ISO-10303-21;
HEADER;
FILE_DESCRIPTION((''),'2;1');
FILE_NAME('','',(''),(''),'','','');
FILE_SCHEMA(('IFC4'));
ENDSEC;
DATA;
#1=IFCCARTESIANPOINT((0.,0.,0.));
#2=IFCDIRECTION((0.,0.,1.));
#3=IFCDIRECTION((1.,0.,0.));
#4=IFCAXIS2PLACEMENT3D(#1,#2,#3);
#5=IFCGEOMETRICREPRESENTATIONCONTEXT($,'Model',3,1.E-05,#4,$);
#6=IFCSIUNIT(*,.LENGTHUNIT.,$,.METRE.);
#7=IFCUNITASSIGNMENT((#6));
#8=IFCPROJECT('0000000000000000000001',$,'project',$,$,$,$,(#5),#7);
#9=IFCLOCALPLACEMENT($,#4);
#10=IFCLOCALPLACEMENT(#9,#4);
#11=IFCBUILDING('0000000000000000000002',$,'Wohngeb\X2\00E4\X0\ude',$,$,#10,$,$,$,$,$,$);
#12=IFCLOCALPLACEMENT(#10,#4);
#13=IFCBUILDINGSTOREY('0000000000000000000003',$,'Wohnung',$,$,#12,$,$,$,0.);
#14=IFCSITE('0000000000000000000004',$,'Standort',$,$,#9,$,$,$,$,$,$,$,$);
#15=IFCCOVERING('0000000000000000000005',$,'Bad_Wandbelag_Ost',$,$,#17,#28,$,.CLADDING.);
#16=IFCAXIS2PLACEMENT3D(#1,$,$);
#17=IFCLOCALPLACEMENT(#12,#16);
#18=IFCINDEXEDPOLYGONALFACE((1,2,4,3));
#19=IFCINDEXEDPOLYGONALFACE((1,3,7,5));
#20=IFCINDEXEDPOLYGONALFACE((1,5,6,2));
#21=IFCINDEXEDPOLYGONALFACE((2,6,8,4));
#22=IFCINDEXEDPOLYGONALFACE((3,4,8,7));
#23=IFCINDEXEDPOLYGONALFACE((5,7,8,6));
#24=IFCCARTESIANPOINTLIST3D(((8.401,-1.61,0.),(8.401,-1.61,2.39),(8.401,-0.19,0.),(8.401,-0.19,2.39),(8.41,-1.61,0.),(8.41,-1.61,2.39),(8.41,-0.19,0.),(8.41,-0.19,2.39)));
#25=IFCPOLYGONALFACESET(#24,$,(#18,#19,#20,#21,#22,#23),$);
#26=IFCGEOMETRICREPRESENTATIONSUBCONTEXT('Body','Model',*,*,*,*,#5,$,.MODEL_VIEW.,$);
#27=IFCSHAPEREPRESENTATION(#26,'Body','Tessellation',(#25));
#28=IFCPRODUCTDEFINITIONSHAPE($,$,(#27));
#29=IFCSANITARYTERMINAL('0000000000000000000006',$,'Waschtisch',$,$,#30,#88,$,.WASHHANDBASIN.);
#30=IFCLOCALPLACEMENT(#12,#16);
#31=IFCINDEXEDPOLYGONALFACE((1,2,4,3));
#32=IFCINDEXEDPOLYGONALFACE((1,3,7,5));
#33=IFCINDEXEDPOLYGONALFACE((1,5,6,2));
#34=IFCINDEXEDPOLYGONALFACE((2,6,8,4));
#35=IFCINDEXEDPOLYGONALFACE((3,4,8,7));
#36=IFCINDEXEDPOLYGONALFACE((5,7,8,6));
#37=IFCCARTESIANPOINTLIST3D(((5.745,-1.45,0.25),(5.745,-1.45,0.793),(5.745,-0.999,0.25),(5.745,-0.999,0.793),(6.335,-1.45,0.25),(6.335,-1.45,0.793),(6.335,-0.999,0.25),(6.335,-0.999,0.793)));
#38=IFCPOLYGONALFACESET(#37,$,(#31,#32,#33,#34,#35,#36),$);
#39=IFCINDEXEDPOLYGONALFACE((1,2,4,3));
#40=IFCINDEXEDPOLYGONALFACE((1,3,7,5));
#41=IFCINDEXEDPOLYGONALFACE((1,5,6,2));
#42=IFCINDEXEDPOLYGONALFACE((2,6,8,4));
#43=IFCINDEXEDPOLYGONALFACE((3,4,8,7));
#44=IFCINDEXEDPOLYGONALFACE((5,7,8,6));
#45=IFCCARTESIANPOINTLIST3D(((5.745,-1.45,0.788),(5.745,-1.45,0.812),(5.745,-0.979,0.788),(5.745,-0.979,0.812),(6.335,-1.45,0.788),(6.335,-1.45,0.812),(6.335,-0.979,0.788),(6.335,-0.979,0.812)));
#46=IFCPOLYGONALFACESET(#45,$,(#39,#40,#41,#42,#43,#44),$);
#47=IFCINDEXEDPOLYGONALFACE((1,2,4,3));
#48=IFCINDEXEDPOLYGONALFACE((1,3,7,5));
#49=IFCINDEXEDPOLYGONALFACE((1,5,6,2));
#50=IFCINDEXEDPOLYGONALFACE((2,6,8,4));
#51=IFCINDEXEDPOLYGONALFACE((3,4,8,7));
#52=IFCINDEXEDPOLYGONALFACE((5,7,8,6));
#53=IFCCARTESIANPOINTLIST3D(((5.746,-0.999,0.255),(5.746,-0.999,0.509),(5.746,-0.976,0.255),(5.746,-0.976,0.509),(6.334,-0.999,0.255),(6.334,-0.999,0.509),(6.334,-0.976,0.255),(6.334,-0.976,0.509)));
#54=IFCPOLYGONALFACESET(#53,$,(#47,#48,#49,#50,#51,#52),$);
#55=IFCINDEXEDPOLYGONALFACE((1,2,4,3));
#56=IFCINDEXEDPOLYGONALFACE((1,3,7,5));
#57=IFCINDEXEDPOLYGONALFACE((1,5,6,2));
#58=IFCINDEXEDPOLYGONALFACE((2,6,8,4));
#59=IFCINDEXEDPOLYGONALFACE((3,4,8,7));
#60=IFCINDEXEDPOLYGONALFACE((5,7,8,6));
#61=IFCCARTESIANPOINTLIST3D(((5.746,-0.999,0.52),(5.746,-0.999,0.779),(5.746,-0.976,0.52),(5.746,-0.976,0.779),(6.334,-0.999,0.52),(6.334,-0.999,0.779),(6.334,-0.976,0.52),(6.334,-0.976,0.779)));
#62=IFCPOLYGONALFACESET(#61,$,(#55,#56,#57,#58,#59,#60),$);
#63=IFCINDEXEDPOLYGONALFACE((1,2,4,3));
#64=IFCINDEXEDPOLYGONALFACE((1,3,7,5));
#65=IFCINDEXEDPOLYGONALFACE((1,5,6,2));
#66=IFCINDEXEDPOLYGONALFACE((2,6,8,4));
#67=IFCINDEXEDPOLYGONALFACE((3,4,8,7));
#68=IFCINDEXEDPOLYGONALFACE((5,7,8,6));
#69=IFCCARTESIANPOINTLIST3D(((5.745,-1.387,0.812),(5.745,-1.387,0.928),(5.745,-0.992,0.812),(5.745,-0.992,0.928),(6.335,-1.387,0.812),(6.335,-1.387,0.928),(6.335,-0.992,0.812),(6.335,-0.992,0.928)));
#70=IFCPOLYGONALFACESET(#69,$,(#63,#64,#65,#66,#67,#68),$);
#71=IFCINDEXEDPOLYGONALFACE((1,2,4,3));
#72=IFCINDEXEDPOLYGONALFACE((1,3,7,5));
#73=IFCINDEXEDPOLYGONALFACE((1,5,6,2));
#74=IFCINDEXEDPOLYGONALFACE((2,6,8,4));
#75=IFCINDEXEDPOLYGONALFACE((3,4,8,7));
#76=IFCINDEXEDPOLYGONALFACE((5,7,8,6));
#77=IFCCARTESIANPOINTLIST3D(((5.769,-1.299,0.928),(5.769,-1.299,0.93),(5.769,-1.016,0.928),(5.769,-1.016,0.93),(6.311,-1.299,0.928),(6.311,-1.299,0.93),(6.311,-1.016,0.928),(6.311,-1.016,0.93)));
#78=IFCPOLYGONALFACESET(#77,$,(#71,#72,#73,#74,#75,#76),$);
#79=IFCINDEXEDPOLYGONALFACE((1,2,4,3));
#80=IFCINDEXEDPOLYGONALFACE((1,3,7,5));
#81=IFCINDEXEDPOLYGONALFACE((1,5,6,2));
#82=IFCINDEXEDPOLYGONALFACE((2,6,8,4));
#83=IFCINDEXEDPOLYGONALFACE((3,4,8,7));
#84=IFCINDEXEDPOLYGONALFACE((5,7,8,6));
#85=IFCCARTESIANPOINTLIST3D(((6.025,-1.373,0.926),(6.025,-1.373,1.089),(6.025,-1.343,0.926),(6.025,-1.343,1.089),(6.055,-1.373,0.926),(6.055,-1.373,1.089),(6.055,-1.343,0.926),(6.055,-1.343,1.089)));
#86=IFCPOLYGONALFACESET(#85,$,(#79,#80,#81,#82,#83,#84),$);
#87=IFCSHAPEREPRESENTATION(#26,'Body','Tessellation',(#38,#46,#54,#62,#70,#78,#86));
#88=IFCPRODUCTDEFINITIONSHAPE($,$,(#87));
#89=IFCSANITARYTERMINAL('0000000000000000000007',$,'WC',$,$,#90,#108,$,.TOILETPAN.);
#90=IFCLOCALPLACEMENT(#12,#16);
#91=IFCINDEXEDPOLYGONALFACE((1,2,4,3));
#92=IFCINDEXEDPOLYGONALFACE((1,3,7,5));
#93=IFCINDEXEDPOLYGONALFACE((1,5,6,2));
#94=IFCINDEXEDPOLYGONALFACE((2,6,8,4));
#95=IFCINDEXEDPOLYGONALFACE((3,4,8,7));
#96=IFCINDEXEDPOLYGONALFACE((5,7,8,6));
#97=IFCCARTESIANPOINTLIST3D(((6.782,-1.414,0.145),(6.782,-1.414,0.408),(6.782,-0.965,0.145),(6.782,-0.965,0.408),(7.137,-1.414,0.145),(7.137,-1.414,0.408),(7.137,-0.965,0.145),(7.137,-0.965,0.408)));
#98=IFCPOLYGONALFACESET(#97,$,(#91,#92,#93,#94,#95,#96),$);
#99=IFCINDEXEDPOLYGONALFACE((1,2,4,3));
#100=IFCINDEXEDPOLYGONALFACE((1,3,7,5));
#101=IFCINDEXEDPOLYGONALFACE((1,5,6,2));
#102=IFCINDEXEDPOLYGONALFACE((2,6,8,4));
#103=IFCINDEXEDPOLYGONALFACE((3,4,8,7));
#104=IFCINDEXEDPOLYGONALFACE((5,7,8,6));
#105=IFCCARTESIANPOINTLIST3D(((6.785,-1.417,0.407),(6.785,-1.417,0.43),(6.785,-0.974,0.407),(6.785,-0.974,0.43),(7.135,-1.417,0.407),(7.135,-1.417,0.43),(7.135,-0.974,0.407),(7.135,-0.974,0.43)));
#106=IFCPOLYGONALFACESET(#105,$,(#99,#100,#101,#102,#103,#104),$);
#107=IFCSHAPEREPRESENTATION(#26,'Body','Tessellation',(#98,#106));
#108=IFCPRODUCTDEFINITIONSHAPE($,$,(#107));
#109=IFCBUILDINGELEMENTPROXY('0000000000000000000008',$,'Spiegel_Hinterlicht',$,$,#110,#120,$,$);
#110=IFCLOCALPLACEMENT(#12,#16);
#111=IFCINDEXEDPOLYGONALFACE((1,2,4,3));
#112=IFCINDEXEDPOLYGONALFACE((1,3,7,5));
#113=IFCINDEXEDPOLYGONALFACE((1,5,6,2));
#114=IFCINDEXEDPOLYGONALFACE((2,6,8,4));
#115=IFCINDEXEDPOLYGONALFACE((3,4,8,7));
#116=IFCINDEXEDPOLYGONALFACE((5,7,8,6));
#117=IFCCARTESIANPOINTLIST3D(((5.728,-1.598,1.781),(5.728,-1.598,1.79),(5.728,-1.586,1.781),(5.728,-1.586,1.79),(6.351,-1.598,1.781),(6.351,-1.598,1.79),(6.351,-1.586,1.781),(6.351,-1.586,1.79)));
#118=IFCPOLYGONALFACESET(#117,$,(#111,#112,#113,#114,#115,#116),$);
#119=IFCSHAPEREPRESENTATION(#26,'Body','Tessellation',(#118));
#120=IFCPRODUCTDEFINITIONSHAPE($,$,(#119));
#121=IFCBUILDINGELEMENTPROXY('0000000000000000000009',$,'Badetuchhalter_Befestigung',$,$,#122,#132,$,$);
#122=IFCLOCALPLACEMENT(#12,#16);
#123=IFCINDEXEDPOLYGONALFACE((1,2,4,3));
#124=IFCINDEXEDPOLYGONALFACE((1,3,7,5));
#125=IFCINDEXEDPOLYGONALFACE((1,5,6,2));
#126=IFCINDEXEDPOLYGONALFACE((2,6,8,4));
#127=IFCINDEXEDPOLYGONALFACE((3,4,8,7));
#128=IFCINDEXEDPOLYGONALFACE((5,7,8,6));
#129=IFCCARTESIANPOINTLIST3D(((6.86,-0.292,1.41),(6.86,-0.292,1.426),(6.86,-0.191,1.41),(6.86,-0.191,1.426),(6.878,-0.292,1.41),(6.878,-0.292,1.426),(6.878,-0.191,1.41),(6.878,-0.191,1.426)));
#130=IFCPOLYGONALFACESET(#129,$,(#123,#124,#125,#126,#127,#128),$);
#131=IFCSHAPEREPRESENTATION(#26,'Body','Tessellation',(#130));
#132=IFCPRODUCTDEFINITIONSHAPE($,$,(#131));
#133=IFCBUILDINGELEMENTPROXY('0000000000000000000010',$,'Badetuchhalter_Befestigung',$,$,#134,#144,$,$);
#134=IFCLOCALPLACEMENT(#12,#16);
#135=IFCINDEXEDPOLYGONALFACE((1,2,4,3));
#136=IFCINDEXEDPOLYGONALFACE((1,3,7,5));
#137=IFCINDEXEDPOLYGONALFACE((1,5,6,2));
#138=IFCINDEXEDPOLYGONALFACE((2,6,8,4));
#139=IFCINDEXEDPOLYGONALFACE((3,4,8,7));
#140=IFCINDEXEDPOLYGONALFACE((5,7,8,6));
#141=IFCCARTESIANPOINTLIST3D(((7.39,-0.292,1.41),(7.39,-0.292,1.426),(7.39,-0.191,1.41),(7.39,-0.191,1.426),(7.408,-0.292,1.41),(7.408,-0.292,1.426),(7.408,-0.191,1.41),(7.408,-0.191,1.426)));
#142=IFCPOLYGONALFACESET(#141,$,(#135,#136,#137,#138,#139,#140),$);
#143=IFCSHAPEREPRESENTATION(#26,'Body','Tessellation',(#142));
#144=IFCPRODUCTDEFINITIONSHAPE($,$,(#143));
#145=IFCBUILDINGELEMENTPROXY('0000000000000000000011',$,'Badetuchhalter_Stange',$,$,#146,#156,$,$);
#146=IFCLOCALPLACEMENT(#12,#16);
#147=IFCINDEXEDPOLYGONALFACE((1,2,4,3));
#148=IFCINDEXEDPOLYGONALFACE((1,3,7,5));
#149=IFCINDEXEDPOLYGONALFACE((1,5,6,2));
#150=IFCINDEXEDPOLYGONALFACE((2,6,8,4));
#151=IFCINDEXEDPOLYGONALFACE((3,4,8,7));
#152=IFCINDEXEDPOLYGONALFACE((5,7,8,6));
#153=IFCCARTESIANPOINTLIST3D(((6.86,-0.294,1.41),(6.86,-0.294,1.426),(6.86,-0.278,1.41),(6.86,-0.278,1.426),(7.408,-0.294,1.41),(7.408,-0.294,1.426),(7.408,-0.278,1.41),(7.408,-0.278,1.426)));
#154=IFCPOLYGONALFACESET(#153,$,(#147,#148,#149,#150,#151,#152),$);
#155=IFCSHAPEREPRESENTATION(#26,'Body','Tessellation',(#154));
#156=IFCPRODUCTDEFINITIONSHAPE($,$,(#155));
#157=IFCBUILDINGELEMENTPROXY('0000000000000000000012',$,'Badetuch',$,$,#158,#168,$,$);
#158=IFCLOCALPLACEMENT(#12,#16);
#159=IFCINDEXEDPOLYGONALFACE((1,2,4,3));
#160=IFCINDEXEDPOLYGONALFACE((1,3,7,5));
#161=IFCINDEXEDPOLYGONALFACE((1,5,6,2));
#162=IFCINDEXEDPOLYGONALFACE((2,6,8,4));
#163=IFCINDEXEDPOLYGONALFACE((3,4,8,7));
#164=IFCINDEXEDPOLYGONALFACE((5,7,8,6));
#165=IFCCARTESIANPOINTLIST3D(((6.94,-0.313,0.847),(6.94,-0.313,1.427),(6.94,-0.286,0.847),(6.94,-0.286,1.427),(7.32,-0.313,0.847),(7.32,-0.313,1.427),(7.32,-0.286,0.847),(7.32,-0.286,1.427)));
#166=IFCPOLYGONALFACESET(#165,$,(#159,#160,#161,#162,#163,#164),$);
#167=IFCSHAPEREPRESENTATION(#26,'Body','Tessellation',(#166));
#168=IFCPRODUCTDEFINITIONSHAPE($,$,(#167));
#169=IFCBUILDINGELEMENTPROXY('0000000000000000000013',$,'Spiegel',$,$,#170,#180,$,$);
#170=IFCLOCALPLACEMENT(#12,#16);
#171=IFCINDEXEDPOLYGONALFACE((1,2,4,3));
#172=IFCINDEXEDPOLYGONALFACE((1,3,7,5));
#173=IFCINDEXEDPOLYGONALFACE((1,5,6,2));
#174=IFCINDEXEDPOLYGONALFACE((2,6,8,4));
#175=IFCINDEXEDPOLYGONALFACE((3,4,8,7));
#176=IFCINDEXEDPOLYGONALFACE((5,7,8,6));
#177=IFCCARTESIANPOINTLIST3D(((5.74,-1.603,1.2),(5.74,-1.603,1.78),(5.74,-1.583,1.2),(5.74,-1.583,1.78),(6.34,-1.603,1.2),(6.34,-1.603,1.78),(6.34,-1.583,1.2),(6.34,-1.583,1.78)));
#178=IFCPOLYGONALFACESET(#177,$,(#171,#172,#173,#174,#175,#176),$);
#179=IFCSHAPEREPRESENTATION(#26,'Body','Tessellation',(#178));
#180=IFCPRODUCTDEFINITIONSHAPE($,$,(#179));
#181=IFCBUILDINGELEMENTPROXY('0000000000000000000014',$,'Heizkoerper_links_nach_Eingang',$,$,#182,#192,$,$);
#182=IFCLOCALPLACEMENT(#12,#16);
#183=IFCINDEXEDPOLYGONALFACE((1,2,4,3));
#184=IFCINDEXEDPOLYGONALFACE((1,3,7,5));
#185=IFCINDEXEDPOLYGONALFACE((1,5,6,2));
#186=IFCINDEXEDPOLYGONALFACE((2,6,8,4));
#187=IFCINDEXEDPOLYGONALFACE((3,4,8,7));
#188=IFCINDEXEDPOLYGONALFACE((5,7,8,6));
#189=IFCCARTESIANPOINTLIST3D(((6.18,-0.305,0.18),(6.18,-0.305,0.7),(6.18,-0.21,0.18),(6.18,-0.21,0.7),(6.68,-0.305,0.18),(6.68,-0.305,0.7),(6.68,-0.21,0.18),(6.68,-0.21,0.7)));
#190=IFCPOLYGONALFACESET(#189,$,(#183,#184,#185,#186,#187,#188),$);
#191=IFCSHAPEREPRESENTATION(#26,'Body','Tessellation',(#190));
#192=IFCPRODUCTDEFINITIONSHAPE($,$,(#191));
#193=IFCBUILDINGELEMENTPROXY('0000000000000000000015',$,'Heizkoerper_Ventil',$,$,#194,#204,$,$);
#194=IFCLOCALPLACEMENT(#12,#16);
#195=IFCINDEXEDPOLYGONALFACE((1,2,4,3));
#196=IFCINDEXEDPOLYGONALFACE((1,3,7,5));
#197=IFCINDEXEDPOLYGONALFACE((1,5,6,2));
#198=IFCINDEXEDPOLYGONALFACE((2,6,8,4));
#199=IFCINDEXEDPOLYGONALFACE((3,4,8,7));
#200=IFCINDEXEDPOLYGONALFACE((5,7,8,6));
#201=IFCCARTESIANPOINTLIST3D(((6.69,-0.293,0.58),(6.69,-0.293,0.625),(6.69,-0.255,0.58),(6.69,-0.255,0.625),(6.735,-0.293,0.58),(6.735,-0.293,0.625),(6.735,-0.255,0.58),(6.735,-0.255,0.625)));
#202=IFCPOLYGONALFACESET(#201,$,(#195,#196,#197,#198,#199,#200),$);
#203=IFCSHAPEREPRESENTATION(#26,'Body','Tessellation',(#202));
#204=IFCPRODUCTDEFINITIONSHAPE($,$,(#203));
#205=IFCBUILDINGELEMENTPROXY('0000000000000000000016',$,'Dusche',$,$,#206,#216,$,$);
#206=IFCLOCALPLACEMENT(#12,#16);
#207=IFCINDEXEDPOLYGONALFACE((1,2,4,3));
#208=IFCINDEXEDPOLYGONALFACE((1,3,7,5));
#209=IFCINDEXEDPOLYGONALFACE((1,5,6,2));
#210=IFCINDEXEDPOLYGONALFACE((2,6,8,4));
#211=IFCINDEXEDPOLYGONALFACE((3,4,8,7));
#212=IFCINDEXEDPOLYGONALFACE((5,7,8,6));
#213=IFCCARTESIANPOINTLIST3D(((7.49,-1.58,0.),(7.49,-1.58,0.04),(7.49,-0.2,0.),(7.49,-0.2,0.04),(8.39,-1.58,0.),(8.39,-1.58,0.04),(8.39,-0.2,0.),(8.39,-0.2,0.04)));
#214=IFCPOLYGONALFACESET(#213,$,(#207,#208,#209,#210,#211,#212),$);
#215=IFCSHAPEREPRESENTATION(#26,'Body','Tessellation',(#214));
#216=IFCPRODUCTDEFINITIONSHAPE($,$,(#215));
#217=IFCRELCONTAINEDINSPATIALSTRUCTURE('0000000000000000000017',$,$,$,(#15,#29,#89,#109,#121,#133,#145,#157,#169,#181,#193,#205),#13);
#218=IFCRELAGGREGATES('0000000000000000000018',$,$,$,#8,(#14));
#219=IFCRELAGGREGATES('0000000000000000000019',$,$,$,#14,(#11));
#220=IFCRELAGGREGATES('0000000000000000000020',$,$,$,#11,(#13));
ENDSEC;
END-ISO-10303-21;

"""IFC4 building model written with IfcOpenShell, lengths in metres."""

from ifc_helpers import new_model, si_unit, frame, origin, origin_with_axes, place, context, subcontext, project, spatial, polyline, outline, extrude, element, save


model = new_model("IFC4")

# Units and contexts
model_context = context("Model", 3, precision=1e-05, world=origin_with_axes())
body_context = subcontext(model_context, "Body", "Model", "MODEL_VIEW")
ifc_project = project(units=[si_unit("LENGTHUNIT", "METRE")], contexts=[model_context])

# Site, building, storey
site_placement = place(None, origin_with_axes())
site = spatial("IfcSite", under=ifc_project, at=site_placement, Name="Standort")
building_placement = place(site_placement, origin_with_axes())
building = spatial("IfcBuilding", under=site, at=building_placement, Name="Wohngebäude")
storey_placement = place(building_placement, origin_with_axes())
storey = spatial("IfcBuildingStorey", under=building, at=storey_placement, Name="Wohnung", Elevation=0.0)

# Covering
covering_placement = place(storey_placement, frame((8.401, -0.19, 0.0), z_axis=(0.0, 0.0, 1.0), x_axis=(1.0, 0.0, 0.0)))
element("IfcCovering", 1, at=covering_placement, inside=storey, Name="Bad_Wandbelag_Ost", PredefinedType="CLADDING", context=body_context, shape_type="SweptSolid", body=[
    extrude(outline(polyline([(0.0, 0.0), (0.0, -1.42), (0.009, -1.42), (0.009, 0.0), (0.0, 0.0)])), origin(), (0.0, 0.0, 1.0), 2.39),
])

# Sanitary terminals
sanitary_terminal_1_placement = place(storey_placement, frame((5.745, -0.976, 0.25), z_axis=(0.0, 0.0, 1.0), x_axis=(1.0, 0.0, 0.0)))
element("IfcSanitaryTerminal", 2, at=sanitary_terminal_1_placement, inside=storey, Name="Waschtisch", PredefinedType="WASHHANDBASIN", context=body_context, shape_type="SweptSolid", body=[
    extrude(outline(polyline([(0.0, -0.023), (0.0, -0.474), (0.59, -0.474), (0.59, -0.023), (0.0, -0.023)])), origin(), (0.0, 0.0, 1.0), 0.543),
    extrude(outline(polyline([(0.0, -0.003), (0.0, -0.474), (0.59, -0.474), (0.59, -0.003), (0.0, -0.003)])), frame((0.0, 0.0, 0.538)), (0.0, 0.0, 1.0), 0.024),
    extrude(outline(polyline([(0.001, 0.0), (0.001, -0.023), (0.589, -0.023), (0.589, 0.0), (0.001, 0.0)])), frame((0.0, 0.0, 0.005)), (0.0, 0.0, 1.0), 0.254),
    extrude(outline(polyline([(0.001, 0.0), (0.001, -0.023), (0.589, -0.023), (0.589, 0.0), (0.001, 0.0)])), frame((0.0, 0.0, 0.27)), (0.0, 0.0, 1.0), 0.259),
    extrude(outline(polyline([(0.0, -0.016), (0.0, -0.411), (0.59, -0.411), (0.59, -0.016), (0.0, -0.016)])), frame((0.0, 0.0, 0.562)), (0.0, 0.0, 1.0), 0.116),
    extrude(outline(polyline([(0.024, -0.04), (0.024, -0.323), (0.566, -0.323), (0.566, -0.04), (0.024, -0.04)])), frame((0.0, 0.0, 0.678)), (0.0, 0.0, 1.0), 0.002),
    extrude(outline(polyline([(0.28, -0.367), (0.28, -0.397), (0.31, -0.397), (0.31, -0.367), (0.28, -0.367)])), frame((0.0, 0.0, 0.676)), (0.0, 0.0, 1.0), 0.163),
])
sanitary_terminal_2_placement = place(storey_placement, frame((6.782, -0.965, 0.145), z_axis=(0.0, 0.0, 1.0), x_axis=(1.0, 0.0, 0.0)))
element("IfcSanitaryTerminal", 3, at=sanitary_terminal_2_placement, inside=storey, Name="WC", PredefinedType="TOILETPAN", context=body_context, shape_type="SweptSolid", body=[
    extrude(outline(polyline([(0.0, 0.0), (0.0, -0.449), (0.355, -0.449), (0.355, 0.0), (0.0, 0.0)])), origin(), (0.0, 0.0, 1.0), 0.263),
    extrude(outline(polyline([(0.003, -0.009), (0.003, -0.452), (0.353, -0.452), (0.353, -0.009), (0.003, -0.009)])), frame((0.0, 0.0, 0.262)), (0.0, 0.0, 1.0), 0.023),
])

# Building element proxies
proxy_1_placement = place(storey_placement, frame((5.728, -1.586, 1.781), z_axis=(0.0, 0.0, 1.0), x_axis=(1.0, 0.0, 0.0)))
element("IfcBuildingElementProxy", 4, at=proxy_1_placement, inside=storey, Name="Spiegel_Hinterlicht", context=body_context, shape_type="SweptSolid", body=[
    extrude(outline(polyline([(0.0, 0.0), (0.0, -0.012), (0.623, -0.012), (0.623, 0.0), (0.0, 0.0)])), origin(), (0.0, 0.0, 1.0), 0.009),
])
for number, where, z_axis, x_axis, name in (
    (5, (6.86, -0.191, 1.41), (0.0, 0.0, 1.0), (1.0, 0.0, 0.0), "Badetuchhalter_Befestigung"),
    (6, (7.39, -0.191, 1.41), (0.0, 0.0, 1.0), (1.0, 0.0, 0.0), "Badetuchhalter_Befestigung"),
):
    element("IfcBuildingElementProxy", number, at=place(storey_placement, frame(where, z_axis=z_axis, x_axis=x_axis)), inside=storey, Name=name, context=body_context, shape_type="SweptSolid", body=[
        extrude(outline(polyline([(0.0, 0.0), (0.0, -0.101), (0.018, -0.101), (0.018, 0.0), (0.0, 0.0)])), origin(), (0.0, 0.0, 1.0), 0.016),
    ])
proxy_2_placement = place(storey_placement, frame((6.86, -0.278, 1.41), z_axis=(0.0, 0.0, 1.0), x_axis=(1.0, 0.0, 0.0)))
element("IfcBuildingElementProxy", 7, at=proxy_2_placement, inside=storey, Name="Badetuchhalter_Stange", context=body_context, shape_type="SweptSolid", body=[
    extrude(outline(polyline([(0.0, 0.0), (0.0, -0.016), (0.548, -0.016), (0.548, 0.0), (0.0, 0.0)])), origin(), (0.0, 0.0, 1.0), 0.016),
])
proxy_3_placement = place(storey_placement, frame((6.94, -0.286, 0.847), z_axis=(0.0, 0.0, 1.0), x_axis=(1.0, 0.0, 0.0)))
element("IfcBuildingElementProxy", 8, at=proxy_3_placement, inside=storey, Name="Badetuch", context=body_context, shape_type="SweptSolid", body=[
    extrude(outline(polyline([(0.0, 0.0), (0.0, -0.027), (0.38, -0.027), (0.38, 0.0), (0.0, 0.0)])), origin(), (0.0, 0.0, 1.0), 0.58),
])
proxy_4_placement = place(storey_placement, frame((5.74, -1.583, 1.2), z_axis=(0.0, 0.0, 1.0), x_axis=(1.0, 0.0, 0.0)))
element("IfcBuildingElementProxy", 9, at=proxy_4_placement, inside=storey, Name="Spiegel", context=body_context, shape_type="SweptSolid", body=[
    extrude(outline(polyline([(0.0, 0.0), (0.0, -0.02), (0.6, -0.02), (0.6, 0.0), (0.0, 0.0)])), origin(), (0.0, 0.0, 1.0), 0.58),
])
proxy_5_placement = place(storey_placement, frame((6.18, -0.21, 0.18), z_axis=(0.0, 0.0, 1.0), x_axis=(1.0, 0.0, 0.0)))
element("IfcBuildingElementProxy", 10, at=proxy_5_placement, inside=storey, Name="Heizkoerper_links_nach_Eingang", context=body_context, shape_type="SweptSolid", body=[
    extrude(outline(polyline([(0.0, 0.0), (0.0, -0.095), (0.5, -0.095), (0.5, 0.0), (0.0, 0.0)])), origin(), (0.0, 0.0, 1.0), 0.52),
])
proxy_6_placement = place(storey_placement, frame((6.69, -0.255, 0.58), z_axis=(0.0, 0.0, 1.0), x_axis=(1.0, 0.0, 0.0)))
element("IfcBuildingElementProxy", 11, at=proxy_6_placement, inside=storey, Name="Heizkoerper_Ventil", context=body_context, shape_type="SweptSolid", body=[
    extrude(outline(polyline([(0.0, 0.0), (0.0, -0.038), (0.045, -0.038), (0.045, 0.0), (0.0, 0.0)])), origin(), (0.0, 0.0, 1.0), 0.045),
])
proxy_7_placement = place(storey_placement, frame((7.49, -0.2, 0.0), z_axis=(0.0, 0.0, 1.0), x_axis=(1.0, 0.0, 0.0)))
element("IfcBuildingElementProxy", 12, at=proxy_7_placement, inside=storey, Name="Dusche", context=body_context, shape_type="SweptSolid", body=[
    extrude(outline(polyline([(0.0, 0.0), (0.0, -1.38), (0.9, -1.38), (0.9, 0.0), (0.0, 0.0)])), origin(), (0.0, 0.0, 1.0), 0.04),
])

save(model, "model.ifc")
